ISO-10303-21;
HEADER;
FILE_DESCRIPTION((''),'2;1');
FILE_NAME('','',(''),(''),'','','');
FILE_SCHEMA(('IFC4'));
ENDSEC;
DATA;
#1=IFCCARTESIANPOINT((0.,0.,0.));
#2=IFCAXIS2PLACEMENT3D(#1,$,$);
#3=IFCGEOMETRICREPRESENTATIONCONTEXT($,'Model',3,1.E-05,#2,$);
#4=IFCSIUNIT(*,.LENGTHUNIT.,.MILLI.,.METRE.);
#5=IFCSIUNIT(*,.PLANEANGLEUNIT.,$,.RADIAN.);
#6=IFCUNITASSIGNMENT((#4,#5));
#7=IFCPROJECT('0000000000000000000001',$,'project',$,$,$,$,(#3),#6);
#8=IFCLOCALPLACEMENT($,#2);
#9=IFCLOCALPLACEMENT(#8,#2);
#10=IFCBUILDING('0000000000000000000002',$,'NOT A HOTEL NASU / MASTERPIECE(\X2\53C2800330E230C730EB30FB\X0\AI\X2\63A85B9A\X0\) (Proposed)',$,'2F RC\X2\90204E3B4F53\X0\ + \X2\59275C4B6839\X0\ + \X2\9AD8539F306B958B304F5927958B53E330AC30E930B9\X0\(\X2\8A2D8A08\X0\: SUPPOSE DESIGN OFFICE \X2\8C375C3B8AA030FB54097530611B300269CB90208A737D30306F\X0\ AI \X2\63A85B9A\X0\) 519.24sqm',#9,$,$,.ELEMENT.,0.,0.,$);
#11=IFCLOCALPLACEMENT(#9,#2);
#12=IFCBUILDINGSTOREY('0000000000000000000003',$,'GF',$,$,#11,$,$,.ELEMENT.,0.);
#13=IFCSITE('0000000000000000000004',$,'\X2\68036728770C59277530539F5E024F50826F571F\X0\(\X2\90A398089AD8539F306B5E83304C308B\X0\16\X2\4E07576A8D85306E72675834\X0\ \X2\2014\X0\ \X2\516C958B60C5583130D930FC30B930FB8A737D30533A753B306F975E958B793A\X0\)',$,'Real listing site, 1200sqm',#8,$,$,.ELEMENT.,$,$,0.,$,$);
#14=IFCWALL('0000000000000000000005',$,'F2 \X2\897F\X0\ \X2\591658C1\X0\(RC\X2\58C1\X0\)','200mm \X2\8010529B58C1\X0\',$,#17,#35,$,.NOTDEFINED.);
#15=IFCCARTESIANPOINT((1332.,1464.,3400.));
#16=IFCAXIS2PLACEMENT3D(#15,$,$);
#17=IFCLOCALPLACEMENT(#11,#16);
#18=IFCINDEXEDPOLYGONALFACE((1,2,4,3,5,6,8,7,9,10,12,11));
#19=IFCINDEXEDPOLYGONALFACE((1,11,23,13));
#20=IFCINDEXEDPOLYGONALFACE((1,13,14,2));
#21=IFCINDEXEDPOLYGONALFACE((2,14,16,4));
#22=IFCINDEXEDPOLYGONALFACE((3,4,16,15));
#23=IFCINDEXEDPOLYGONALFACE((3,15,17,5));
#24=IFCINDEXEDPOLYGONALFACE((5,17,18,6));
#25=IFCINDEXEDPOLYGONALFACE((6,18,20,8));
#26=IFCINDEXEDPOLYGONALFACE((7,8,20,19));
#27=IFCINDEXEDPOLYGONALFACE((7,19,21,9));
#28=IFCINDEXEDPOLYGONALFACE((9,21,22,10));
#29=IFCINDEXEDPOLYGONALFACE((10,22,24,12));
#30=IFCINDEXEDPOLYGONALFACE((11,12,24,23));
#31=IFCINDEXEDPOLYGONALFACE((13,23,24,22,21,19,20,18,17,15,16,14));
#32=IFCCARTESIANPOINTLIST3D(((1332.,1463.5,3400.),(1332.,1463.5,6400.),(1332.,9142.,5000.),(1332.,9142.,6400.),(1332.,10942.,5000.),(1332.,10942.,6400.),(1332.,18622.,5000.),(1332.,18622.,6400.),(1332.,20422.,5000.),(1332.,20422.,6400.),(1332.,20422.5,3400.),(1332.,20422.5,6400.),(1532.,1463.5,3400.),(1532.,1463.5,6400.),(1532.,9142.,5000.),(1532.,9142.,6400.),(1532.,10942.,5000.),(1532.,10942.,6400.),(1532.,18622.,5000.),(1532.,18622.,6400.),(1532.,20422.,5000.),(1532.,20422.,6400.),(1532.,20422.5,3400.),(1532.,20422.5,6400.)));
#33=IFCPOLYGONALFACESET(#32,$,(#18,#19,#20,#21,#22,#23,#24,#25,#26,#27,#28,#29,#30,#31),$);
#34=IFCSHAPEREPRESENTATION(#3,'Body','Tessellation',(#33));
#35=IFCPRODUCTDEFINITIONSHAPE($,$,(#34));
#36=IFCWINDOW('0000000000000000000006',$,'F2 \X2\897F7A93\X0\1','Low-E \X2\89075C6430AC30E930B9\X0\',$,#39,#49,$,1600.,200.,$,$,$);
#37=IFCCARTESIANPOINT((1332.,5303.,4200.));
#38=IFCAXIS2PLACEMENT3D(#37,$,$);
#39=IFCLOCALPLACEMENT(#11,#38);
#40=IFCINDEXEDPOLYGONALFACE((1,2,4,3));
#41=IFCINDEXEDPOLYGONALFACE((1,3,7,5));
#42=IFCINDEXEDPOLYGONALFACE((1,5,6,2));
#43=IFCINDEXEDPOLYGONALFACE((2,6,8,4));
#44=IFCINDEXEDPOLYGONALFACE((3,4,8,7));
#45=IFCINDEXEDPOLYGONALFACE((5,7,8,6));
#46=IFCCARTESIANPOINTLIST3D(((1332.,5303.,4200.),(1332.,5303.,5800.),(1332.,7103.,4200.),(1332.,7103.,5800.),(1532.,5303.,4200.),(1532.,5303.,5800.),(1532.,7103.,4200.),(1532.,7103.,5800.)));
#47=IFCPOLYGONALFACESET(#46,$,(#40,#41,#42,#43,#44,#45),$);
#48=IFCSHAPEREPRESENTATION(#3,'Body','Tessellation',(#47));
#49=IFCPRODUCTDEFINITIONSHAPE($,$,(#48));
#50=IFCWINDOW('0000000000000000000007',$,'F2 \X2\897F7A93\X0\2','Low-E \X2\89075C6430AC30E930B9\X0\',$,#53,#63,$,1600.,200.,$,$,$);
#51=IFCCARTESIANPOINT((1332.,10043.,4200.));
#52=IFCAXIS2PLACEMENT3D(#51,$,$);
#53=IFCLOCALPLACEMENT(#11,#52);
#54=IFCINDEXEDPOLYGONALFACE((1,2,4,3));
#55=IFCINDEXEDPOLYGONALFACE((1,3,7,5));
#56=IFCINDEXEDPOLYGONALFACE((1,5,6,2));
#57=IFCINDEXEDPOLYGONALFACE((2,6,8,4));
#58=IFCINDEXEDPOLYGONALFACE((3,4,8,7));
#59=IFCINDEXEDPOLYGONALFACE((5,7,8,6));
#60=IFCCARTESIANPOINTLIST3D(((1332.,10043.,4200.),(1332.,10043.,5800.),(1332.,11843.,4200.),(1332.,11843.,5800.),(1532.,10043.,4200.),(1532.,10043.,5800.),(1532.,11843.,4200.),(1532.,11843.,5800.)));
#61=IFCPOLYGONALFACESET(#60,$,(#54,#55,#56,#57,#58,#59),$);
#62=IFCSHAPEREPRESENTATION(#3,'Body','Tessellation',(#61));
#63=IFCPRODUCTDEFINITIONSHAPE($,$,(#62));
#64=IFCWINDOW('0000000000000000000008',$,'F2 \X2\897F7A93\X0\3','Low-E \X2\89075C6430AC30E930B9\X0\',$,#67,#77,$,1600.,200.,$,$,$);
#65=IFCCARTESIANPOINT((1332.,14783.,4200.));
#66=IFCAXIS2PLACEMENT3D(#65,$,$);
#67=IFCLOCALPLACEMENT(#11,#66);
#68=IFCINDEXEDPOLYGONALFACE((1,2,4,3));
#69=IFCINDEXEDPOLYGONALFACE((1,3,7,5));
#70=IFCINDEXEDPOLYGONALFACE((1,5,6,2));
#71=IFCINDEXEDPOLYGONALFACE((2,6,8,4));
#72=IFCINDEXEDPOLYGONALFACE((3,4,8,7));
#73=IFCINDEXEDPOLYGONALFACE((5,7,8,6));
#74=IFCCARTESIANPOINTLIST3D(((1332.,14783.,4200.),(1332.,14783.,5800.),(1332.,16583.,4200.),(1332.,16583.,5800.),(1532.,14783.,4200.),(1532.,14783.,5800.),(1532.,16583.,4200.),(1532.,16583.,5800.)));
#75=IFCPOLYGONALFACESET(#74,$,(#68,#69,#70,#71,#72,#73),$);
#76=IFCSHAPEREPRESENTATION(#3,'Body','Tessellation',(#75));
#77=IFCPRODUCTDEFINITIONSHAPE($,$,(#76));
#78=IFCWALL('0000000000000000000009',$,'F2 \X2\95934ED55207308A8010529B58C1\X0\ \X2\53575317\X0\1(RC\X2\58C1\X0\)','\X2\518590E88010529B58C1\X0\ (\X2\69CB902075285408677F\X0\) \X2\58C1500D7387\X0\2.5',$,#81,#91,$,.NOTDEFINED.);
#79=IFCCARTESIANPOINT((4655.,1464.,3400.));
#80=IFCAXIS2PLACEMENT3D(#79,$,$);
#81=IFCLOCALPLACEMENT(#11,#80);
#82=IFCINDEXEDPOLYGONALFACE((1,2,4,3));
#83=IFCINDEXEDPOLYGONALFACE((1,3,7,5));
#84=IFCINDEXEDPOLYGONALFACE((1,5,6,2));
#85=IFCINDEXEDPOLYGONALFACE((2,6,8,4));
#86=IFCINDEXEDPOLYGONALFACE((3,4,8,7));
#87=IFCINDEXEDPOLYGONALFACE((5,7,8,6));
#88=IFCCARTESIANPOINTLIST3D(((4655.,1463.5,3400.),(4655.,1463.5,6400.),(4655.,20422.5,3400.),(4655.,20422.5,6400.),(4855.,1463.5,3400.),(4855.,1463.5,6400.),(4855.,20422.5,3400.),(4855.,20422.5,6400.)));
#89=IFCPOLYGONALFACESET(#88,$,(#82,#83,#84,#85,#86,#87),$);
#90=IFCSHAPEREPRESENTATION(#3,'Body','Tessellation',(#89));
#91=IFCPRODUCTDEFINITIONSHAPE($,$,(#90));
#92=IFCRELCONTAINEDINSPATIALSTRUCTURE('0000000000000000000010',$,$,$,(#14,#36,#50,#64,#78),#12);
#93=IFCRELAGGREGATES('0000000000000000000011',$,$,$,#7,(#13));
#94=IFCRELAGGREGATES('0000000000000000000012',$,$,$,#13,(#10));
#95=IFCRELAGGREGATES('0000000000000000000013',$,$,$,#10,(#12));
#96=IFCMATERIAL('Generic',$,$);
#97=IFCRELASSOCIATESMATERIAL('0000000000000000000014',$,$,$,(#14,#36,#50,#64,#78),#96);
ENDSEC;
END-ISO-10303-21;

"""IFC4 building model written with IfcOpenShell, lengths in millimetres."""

from ifc_helpers import new_model, si_unit, frame, frame_2d, origin, place, context, project, spatial, rectangle, extrude, material, element, fill, save


model = new_model("IFC4")

# Units and contexts
model_context = context("Model", 3, precision=1e-05, world=origin())
ifc_project = project(units=[si_unit("LENGTHUNIT", "METRE", prefix="MILLI"), si_unit("PLANEANGLEUNIT", "RADIAN")], contexts=[model_context])

# Site, building, storey
site_placement = place(None, origin())
site = spatial("IfcSite", under=ifc_project, at=site_placement, Name="栃木県大田原市佐良土(那須高原に広がる16万坪超の牧場 — 公開情報ベース・詳細区画は非開示)", ObjectType="Real listing site, 1200sqm", CompositionType="ELEMENT", RefElevation=0.0)
building_placement = place(site_placement, origin())
building = spatial("IfcBuilding", under=site, at=building_placement, Name="NOT A HOTEL NASU / MASTERPIECE(参考モデル・AI推定) (Proposed)", ObjectType="2F RC造主体 + 大屋根 + 高原に開く大開口ガラス(設計: SUPPOSE DESIGN OFFICE 谷尻誠・吉田愛。構造詳細は AI 推定) 519.24sqm", CompositionType="ELEMENT", ElevationOfRefHeight=0.0, ElevationOfTerrain=0.0)
storey_placement = place(building_placement, origin())
storey = spatial("IfcBuildingStorey", under=building, at=storey_placement, Name="GF", CompositionType="ELEMENT", Elevation=0.0)

# Shared definitions
ifc_material = material(Name="Generic")

# Wall, openings, windows
wall_1_placement = place(storey_placement, frame((1332.0, 1464.0, 3400.0)))
wall_1 = element("IfcWall", 1, at=wall_1_placement, inside=storey, material=ifc_material, Name="F2 西 外壁(RC壁)", Description="200mm 耐力壁", PredefinedType="NOTDEFINED", context=model_context, shape_type="SweptSolid", body=[
    extrude(rectangle(XDim=200.0, YDim=18959.0, at=frame_2d((100.0, 9479.0))), frame((1332.0, 1464.0, 3400.0)), (0.0, 0.0, 1.0), 3000.0),
])
opening_1_placement = place(storey_placement, frame((1332.0, 5303.0, 4200.0)))
opening_1 = element("IfcOpeningElement", 2, at=opening_1_placement, cuts=wall_1, PredefinedType="NOTDEFINED", context=model_context, shape_type="SweptSolid", body=[
    extrude(rectangle(XDim=200.0, YDim=1800.0, at=frame_2d((100.0, 900.0))), frame((1332.0, 5303.0, 4200.0)), (0.0, 0.0, 1.0), 1600.0),
])
opening_2_placement = place(storey_placement, frame((1332.0, 10043.0, 4200.0)))
opening_2 = element("IfcOpeningElement", 3, at=opening_2_placement, cuts=wall_1, PredefinedType="NOTDEFINED", context=model_context, shape_type="SweptSolid", body=[
    extrude(rectangle(XDim=200.0, YDim=1800.0, at=frame_2d((100.0, 900.0))), frame((1332.0, 10043.0, 4200.0)), (0.0, 0.0, 1.0), 1600.0),
])
opening_3_placement = place(storey_placement, frame((1332.0, 14783.0, 4200.0)))
opening_3 = element("IfcOpeningElement", 4, at=opening_3_placement, cuts=wall_1, PredefinedType="NOTDEFINED", context=model_context, shape_type="SweptSolid", body=[
    extrude(rectangle(XDim=200.0, YDim=1800.0, at=frame_2d((100.0, 900.0))), frame((1332.0, 14783.0, 4200.0)), (0.0, 0.0, 1.0), 1600.0),
])
window_1_placement = place(storey_placement, frame((1332.0, 5303.0, 4200.0)))
window_1 = element("IfcWindow", 5, at=window_1_placement, inside=storey, material=ifc_material, Name="F2 西窓1", Description="Low-E 複層ガラス", OverallHeight=1600.0, OverallWidth=200.0, context=model_context, shape_type="SweptSolid", body=[
    extrude(rectangle(XDim=200.0, YDim=1800.0, at=frame_2d((100.0, 900.0))), frame((1332.0, 5303.0, 4200.0)), (0.0, 0.0, 1.0), 1600.0),
])
fill(opening_1, window_1)
window_2_placement = place(storey_placement, frame((1332.0, 10043.0, 4200.0)))
window_2 = element("IfcWindow", 6, at=window_2_placement, inside=storey, material=ifc_material, Name="F2 西窓2", Description="Low-E 複層ガラス", OverallHeight=1600.0, OverallWidth=200.0, context=model_context, shape_type="SweptSolid", body=[
    extrude(rectangle(XDim=200.0, YDim=1800.0, at=frame_2d((100.0, 900.0))), frame((1332.0, 10043.0, 4200.0)), (0.0, 0.0, 1.0), 1600.0),
])
fill(opening_2, window_2)
window_3_placement = place(storey_placement, frame((1332.0, 14783.0, 4200.0)))
window_3 = element("IfcWindow", 7, at=window_3_placement, inside=storey, material=ifc_material, Name="F2 西窓3", Description="Low-E 複層ガラス", OverallHeight=1600.0, OverallWidth=200.0, context=model_context, shape_type="SweptSolid", body=[
    extrude(rectangle(XDim=200.0, YDim=1800.0, at=frame_2d((100.0, 900.0))), frame((1332.0, 14783.0, 4200.0)), (0.0, 0.0, 1.0), 1600.0),
])
fill(opening_3, window_3)

# Wall
wall_2_placement = place(storey_placement, frame((4655.0, 1464.0, 3400.0)))
element("IfcWall", 8, at=wall_2_placement, inside=storey, material=ifc_material, Name="F2 間仕切り耐力壁 南北1(RC壁)", Description="内部耐力壁 (構造用合板) 壁倍率2.5", PredefinedType="NOTDEFINED", context=model_context, shape_type="SweptSolid", body=[
    extrude(rectangle(XDim=200.0, YDim=18959.0, at=frame_2d((100.0, 9479.0))), frame((4655.0, 1464.0, 3400.0)), (0.0, 0.0, 1.0), 3000.0),
])

save(model, "model.ifc")
